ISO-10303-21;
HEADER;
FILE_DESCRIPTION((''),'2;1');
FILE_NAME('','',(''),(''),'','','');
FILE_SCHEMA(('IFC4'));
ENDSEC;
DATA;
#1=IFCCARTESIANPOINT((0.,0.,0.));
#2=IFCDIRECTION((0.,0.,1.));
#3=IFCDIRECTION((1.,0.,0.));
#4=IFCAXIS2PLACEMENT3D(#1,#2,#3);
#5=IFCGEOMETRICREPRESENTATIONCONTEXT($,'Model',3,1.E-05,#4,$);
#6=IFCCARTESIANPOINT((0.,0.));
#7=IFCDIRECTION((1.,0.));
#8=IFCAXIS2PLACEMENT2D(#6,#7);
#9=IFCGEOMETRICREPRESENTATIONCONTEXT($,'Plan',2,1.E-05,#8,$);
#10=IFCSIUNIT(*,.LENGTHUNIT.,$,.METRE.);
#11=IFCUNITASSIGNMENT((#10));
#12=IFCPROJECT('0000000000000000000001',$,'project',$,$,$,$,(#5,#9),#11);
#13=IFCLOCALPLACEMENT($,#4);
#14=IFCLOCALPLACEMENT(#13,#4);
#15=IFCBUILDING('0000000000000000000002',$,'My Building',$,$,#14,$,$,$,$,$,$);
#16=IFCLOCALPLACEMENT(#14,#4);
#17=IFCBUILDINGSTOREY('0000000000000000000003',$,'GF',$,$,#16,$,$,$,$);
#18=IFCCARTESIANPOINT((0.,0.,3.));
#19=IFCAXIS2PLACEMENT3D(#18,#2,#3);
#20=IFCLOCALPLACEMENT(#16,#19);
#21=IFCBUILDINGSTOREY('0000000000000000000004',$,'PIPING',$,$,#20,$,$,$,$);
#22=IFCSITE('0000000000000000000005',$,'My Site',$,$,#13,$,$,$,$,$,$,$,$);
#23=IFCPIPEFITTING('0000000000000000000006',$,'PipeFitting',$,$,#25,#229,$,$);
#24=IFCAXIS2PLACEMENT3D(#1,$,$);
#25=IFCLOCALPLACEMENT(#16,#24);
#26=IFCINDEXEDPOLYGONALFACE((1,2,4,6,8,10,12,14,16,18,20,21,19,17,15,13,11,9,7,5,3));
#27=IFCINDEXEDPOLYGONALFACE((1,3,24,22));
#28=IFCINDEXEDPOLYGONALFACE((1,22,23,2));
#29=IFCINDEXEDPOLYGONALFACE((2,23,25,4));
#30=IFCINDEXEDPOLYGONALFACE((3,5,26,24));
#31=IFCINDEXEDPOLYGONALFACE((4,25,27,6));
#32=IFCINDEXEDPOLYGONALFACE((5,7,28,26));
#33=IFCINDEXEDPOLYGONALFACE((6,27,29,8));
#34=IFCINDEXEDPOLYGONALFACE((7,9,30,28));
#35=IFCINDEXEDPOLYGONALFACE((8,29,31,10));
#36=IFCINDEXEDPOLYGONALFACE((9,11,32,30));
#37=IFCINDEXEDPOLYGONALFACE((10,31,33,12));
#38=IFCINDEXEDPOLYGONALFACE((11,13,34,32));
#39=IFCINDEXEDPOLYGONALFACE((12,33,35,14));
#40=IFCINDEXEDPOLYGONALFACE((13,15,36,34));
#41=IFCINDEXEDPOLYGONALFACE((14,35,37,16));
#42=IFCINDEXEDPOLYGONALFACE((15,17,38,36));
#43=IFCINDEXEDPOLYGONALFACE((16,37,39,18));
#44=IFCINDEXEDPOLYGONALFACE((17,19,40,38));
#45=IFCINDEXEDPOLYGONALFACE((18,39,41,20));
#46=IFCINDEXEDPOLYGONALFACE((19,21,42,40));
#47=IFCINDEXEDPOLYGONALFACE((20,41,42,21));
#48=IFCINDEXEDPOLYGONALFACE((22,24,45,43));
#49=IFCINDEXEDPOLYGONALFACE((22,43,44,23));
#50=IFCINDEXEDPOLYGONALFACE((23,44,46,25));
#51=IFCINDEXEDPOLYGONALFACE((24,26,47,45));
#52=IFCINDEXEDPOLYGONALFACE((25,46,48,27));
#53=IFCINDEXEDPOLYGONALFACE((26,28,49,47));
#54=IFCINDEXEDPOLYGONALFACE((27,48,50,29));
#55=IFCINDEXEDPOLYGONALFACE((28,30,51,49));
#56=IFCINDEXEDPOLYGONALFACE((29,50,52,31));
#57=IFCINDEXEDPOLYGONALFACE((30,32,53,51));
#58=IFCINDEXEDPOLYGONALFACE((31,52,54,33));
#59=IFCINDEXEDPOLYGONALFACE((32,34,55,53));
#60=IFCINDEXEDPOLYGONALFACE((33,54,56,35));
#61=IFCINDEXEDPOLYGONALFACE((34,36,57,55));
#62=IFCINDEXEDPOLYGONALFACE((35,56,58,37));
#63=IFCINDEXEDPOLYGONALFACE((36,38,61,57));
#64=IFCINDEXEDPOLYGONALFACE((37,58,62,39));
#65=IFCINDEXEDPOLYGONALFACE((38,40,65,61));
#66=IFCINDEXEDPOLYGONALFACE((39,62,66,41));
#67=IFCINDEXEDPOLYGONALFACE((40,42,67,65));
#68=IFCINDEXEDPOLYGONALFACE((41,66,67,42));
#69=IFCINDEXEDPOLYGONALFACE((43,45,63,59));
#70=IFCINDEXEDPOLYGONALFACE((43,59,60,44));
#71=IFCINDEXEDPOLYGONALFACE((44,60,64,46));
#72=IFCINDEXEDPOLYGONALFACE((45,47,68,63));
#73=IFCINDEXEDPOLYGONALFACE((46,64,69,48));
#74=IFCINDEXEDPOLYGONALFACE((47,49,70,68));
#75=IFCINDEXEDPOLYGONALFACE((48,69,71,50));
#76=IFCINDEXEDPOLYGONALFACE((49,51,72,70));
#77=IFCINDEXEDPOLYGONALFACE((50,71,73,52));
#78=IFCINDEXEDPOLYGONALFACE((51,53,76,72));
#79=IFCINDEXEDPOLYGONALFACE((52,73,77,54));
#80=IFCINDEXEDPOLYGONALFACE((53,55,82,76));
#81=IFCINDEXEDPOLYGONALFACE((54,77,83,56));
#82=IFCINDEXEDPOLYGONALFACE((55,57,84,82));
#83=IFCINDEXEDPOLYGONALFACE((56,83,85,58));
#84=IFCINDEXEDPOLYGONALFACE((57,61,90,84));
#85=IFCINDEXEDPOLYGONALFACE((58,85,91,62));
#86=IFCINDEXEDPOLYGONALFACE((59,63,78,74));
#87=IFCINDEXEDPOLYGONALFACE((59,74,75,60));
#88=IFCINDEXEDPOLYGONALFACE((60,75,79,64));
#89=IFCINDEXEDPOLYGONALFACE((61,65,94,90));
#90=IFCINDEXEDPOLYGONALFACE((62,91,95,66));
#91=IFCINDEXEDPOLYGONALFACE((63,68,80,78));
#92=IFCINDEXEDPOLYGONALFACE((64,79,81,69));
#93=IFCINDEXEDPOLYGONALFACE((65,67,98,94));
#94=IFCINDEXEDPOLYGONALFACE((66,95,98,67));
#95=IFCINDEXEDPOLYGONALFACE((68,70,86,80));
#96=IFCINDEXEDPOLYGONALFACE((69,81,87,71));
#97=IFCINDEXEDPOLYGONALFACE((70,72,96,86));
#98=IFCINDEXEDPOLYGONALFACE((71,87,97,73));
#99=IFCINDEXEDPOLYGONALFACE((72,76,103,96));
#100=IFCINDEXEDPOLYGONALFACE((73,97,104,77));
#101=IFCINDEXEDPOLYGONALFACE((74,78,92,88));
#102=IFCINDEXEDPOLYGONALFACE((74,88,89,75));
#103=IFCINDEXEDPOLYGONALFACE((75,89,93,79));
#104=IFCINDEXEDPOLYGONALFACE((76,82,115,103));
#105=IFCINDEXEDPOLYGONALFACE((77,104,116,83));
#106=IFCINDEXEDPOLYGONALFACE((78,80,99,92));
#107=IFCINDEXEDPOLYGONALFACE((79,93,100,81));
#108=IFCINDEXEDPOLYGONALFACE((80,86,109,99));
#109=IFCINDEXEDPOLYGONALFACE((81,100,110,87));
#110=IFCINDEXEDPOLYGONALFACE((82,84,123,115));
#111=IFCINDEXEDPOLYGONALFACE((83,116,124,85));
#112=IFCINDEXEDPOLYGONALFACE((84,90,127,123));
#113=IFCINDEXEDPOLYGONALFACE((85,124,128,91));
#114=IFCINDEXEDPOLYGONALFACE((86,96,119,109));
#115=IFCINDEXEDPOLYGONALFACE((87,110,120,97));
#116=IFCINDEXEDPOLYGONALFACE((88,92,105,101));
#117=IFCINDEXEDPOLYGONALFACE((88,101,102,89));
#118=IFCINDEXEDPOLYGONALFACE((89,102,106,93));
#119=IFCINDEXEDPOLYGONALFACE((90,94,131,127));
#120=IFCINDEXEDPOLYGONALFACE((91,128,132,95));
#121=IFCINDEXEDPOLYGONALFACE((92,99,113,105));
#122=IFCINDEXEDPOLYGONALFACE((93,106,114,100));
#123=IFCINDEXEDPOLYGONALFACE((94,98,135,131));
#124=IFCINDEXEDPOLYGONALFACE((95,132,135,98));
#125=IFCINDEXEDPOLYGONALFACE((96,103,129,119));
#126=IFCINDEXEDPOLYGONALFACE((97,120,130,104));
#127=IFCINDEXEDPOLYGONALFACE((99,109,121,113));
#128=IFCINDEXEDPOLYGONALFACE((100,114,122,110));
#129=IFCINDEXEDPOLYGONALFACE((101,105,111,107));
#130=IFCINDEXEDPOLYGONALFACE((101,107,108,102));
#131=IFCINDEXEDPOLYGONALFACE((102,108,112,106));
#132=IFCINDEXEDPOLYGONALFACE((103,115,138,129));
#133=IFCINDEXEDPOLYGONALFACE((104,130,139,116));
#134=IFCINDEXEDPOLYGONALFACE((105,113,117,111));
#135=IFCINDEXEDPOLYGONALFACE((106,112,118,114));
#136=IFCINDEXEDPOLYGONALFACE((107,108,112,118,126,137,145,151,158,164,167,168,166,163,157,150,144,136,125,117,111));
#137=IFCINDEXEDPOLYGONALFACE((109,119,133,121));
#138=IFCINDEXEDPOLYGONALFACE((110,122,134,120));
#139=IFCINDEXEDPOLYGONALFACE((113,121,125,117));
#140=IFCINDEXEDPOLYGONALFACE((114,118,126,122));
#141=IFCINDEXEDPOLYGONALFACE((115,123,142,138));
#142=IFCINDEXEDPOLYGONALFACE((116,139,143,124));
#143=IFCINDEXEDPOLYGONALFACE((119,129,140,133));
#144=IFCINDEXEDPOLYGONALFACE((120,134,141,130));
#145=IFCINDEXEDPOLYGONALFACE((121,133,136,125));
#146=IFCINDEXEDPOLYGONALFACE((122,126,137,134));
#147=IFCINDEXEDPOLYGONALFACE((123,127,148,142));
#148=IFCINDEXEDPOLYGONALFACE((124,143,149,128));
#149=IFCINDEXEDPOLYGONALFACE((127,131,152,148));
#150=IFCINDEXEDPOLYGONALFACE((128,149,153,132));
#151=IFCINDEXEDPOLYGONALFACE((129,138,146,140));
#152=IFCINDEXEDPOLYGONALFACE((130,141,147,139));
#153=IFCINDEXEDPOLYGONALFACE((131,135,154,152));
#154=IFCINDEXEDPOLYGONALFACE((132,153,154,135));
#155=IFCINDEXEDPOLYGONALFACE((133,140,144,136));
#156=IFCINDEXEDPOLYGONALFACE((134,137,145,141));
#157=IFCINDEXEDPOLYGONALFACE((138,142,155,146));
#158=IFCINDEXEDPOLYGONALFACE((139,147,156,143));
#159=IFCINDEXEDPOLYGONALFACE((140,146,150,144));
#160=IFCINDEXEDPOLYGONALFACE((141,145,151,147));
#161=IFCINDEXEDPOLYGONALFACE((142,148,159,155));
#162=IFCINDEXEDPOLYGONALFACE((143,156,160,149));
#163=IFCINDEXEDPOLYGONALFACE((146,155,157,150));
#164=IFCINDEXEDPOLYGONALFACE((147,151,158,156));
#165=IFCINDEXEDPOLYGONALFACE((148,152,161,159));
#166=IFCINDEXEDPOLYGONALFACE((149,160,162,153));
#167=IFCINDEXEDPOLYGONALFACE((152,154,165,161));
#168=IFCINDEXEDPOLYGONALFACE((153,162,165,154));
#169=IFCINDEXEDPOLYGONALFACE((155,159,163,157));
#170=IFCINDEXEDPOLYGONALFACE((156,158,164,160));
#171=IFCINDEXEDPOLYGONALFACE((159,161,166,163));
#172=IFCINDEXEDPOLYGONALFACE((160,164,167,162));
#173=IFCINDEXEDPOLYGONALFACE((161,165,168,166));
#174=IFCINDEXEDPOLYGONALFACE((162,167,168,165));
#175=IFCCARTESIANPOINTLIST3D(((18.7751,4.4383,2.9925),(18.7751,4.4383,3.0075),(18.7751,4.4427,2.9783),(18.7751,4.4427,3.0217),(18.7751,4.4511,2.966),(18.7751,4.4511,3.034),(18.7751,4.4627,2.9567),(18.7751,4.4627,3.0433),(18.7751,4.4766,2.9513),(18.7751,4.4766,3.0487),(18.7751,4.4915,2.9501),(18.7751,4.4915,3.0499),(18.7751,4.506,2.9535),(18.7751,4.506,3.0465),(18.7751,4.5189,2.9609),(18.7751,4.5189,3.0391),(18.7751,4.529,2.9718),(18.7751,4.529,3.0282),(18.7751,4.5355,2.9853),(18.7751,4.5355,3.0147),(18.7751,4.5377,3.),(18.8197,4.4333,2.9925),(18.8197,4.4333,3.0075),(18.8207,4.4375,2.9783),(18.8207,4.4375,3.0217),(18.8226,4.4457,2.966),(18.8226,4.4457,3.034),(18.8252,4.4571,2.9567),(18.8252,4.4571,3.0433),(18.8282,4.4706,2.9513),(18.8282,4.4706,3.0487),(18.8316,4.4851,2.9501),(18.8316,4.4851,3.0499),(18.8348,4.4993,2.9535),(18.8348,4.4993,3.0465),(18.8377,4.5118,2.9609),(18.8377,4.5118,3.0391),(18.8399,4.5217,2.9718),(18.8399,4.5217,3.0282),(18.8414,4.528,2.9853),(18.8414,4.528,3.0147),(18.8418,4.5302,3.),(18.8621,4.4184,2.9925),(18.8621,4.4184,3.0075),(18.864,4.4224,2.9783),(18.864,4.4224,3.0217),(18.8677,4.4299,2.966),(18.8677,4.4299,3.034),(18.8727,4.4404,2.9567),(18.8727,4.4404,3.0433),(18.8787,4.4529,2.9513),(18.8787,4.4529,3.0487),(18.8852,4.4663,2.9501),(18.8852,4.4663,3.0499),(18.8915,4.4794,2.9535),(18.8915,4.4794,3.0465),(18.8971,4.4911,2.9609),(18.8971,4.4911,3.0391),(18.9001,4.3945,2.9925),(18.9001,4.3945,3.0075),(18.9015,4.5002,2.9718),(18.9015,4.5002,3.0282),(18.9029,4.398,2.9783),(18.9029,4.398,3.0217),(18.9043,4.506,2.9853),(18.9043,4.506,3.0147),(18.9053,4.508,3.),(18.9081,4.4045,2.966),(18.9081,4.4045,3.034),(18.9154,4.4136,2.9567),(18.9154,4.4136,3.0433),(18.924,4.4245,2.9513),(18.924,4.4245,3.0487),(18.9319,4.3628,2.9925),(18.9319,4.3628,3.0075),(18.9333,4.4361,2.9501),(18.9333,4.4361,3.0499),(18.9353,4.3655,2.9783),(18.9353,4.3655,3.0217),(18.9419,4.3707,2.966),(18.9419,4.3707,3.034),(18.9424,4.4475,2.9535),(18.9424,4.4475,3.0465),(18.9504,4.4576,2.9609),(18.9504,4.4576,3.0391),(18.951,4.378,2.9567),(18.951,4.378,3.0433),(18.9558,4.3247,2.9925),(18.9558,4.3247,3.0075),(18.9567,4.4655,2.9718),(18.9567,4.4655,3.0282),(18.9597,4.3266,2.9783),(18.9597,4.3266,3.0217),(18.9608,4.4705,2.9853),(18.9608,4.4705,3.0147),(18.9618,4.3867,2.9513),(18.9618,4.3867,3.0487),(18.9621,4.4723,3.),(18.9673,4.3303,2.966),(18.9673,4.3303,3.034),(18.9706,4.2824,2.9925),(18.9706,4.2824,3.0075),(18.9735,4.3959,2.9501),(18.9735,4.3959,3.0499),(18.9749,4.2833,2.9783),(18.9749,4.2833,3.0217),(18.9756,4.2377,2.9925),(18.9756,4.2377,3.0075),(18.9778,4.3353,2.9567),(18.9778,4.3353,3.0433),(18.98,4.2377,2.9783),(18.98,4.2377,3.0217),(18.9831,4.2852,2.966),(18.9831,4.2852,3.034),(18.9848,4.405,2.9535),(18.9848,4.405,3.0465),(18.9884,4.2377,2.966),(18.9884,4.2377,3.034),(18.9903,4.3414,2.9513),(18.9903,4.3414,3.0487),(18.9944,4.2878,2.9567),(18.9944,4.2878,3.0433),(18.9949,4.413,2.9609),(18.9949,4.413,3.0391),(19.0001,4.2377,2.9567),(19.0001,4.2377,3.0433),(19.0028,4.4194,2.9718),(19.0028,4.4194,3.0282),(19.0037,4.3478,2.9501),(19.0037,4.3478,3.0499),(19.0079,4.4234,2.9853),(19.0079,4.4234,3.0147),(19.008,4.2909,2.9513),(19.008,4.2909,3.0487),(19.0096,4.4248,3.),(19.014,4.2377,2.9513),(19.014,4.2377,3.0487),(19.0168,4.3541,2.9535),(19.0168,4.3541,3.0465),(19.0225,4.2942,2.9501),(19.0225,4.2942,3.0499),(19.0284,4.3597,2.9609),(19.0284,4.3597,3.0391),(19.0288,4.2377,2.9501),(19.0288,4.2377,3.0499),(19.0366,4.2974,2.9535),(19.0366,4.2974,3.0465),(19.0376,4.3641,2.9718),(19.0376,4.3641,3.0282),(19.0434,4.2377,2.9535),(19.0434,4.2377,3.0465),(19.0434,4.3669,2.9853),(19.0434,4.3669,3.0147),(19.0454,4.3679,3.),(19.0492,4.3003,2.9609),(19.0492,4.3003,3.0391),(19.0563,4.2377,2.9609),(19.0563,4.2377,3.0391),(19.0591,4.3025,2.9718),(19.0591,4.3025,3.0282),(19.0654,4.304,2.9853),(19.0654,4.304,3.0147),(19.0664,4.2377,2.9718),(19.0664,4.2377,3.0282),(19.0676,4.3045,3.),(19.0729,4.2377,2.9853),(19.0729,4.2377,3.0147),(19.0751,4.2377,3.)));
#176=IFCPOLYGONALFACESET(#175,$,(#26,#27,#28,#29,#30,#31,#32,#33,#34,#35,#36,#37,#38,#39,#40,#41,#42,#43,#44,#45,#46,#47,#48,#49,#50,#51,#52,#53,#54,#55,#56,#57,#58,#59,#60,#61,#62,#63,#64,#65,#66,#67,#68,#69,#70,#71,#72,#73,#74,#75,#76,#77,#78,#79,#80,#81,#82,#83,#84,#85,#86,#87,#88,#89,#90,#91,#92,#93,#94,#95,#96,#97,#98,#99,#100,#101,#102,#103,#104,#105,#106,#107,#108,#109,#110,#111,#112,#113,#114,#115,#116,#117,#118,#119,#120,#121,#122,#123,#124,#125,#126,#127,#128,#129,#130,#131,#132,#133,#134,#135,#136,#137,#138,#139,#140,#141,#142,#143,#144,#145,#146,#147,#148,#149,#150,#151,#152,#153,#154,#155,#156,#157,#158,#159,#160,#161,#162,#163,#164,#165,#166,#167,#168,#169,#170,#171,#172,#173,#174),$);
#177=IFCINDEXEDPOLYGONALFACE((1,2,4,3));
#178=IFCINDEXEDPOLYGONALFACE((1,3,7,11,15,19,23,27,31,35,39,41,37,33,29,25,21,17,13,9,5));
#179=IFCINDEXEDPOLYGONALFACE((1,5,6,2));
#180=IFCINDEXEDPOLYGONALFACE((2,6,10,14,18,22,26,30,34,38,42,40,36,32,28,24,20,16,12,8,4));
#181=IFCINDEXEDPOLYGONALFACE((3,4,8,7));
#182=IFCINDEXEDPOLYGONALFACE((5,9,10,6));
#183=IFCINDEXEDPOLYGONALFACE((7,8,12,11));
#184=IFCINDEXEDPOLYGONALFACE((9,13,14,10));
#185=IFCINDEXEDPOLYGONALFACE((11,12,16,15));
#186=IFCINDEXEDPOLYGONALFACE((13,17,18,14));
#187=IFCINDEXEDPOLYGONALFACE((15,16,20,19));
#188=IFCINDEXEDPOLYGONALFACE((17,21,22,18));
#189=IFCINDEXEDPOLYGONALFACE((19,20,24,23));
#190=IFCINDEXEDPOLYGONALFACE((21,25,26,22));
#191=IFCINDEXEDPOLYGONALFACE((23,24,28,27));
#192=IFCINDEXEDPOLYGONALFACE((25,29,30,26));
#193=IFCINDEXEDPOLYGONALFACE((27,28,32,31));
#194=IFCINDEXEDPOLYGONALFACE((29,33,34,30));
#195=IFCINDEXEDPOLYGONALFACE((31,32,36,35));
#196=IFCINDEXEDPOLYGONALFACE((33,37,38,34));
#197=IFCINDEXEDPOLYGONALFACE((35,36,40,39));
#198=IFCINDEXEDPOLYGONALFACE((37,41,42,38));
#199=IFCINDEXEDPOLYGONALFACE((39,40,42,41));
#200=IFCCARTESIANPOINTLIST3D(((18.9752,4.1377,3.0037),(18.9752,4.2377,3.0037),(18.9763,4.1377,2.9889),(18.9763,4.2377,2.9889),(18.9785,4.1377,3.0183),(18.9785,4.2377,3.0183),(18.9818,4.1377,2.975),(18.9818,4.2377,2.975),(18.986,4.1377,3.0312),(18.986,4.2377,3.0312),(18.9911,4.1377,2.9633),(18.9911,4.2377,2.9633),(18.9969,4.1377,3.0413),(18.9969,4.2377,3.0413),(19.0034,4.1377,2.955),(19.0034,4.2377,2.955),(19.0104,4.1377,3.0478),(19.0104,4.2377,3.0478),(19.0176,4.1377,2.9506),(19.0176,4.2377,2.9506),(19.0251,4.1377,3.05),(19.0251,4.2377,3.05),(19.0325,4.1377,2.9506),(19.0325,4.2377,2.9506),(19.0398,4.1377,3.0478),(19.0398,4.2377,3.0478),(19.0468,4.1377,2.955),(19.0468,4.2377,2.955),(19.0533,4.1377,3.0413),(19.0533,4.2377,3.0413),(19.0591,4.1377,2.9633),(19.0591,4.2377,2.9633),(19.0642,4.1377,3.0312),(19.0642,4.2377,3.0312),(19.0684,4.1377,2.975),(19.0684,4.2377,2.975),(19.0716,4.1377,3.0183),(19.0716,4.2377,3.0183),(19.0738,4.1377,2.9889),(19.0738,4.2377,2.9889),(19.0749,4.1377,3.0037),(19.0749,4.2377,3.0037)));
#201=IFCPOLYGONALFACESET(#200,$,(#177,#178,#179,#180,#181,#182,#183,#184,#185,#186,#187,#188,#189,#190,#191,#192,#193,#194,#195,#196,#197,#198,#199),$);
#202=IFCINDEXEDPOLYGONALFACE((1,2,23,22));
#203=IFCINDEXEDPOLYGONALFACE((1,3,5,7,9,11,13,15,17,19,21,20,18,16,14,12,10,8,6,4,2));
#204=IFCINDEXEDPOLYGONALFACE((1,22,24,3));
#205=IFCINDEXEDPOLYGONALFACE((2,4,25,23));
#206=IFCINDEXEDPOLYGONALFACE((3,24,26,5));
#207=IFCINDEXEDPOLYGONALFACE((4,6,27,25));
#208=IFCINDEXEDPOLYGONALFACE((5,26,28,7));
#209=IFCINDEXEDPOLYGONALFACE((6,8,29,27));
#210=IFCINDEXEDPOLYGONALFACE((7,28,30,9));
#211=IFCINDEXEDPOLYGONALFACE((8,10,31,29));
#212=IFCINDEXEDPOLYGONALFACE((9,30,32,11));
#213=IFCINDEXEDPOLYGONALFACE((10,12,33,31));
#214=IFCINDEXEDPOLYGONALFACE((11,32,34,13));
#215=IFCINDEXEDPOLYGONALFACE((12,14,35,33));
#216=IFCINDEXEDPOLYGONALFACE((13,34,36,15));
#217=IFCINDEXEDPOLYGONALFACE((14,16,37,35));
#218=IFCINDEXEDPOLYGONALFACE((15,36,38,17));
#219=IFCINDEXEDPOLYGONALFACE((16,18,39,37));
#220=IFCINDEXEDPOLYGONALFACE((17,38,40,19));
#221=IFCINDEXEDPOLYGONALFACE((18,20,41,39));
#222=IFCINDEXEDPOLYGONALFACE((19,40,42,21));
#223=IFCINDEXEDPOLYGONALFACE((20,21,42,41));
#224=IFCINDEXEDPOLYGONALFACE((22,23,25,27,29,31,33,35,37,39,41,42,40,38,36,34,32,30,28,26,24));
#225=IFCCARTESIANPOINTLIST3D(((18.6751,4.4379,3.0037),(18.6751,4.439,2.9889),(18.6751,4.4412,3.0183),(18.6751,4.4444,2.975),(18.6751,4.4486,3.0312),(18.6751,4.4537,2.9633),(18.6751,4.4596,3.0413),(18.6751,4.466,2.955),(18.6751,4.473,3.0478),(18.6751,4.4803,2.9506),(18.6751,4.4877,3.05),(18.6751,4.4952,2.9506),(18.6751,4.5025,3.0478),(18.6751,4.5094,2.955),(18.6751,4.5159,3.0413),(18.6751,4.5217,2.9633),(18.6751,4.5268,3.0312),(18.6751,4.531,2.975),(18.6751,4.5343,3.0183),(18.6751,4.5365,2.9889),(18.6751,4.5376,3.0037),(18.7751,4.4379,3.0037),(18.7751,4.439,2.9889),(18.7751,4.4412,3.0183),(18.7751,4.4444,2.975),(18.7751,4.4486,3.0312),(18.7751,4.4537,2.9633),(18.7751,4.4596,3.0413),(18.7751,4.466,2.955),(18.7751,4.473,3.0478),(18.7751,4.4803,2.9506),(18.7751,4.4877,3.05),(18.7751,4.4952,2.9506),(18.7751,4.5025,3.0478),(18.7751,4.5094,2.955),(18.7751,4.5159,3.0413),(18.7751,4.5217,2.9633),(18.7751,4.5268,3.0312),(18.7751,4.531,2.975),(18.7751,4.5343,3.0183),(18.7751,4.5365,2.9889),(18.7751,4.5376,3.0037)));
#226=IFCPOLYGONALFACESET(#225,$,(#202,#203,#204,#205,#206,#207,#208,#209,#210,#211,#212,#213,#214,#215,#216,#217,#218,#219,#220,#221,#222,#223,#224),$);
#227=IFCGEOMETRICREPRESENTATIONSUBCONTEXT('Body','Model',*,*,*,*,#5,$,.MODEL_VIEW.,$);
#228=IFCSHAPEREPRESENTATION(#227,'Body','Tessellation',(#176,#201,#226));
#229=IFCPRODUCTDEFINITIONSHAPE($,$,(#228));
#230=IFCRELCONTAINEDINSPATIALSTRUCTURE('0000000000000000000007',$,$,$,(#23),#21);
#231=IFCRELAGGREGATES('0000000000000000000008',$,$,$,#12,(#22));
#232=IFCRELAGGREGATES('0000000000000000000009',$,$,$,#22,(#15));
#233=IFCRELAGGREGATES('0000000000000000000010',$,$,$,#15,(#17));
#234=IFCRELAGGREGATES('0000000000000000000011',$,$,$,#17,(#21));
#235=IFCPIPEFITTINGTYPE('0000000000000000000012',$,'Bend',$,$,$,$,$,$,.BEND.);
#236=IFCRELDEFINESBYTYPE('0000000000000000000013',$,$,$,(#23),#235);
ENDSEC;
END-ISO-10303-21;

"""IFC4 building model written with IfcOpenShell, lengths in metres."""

from ifc_helpers import new_model, entity, si_unit, frame, origin_with_axes, origin_2d_with_axis, place, context, subcontext, project, spatial, circle, extrude, source, transform, mapped, type_object, type_shapes, element, save


model = new_model("IFC4")

# Units and contexts
model_context = context("Model", 3, precision=1e-05, world=origin_with_axes())
plan_context = context("Plan", 2, precision=1e-05, world=origin_2d_with_axis())
body_context = subcontext(model_context, "Body", "Model", "MODEL_VIEW")
ifc_project = project(units=[si_unit("LENGTHUNIT", "METRE")], contexts=[model_context, plan_context])

# Site, building, storeys
site_placement = place(None, origin_with_axes())
site = spatial("IfcSite", under=ifc_project, at=site_placement, Name="My Site")
building_placement = place(site_placement, origin_with_axes())
building = spatial("IfcBuilding", under=site, at=building_placement, Name="My Building")
storey_1_placement = place(building_placement, origin_with_axes())
storey_1 = spatial("IfcBuildingStorey", under=building, at=storey_1_placement, Name="GF")
storey_2_placement = place(storey_1_placement, frame((0.0, 0.0, 3.0), z_axis=(0.0, 0.0, 1.0), x_axis=(1.0, 0.0, 0.0)))
storey_2 = spatial("IfcBuildingStorey", under=storey_1, at=storey_2_placement, Name="PIPING")

# Pipe fitting
pipe_fitting_type = type_object("IfcPipeFittingType", Name="Bend", PredefinedType="BEND")
shared_shape = source(origin_with_axes(), body_context, "Body", "SolidModel", [
    entity("IfcSweptDiskSolid", entity("IfcIndexedPolyCurve", entity("IfcCartesianPointList3D", [[0.0, 0.0, -0.1], [0.0, 0.0732, -0.2768], [0.0, 0.25, -0.35]]), [entity("IfcArcIndex", [1, 2, 3])]), 0.05),
    extrude(circle(Radius=0.05), origin_with_axes(), (0.0, 0.0, -1.0), 0.1),
    extrude(circle(Radius=0.05), frame((0.0, 0.25, -0.35), z_axis=(0.0, 1.0, 0.0), x_axis=(1.0, 0.0, 0.0)), (0.0, 0.0, 1.0), 0.1),
])
type_shapes(pipe_fitting_type, [shared_shape])
for number, where, z_axis, x_axis, name in (
    (1, (19.0251, 4.1377, 0.0), (0.0, -1.0, 0.0), (0.0, 0.0, 1.0), "PipeFitting"),
):
    element("IfcPipeFitting", number, at=place(storey_2_placement, frame(where, z_axis=z_axis, x_axis=x_axis)), inside=storey_2, type_object=pipe_fitting_type, Name=name, context=body_context, shape_type="MappedRepresentation", body=[
        mapped(shared_shape, transform((0.0, 0.0, 0.0), x_axis=(1.0, 0.0, 0.0), y_axis=(0.0, 1.0, 0.0), z_axis=(0.0, 0.0, 1.0), scale=1.0)),
    ])

save(model, "model.ifc")
